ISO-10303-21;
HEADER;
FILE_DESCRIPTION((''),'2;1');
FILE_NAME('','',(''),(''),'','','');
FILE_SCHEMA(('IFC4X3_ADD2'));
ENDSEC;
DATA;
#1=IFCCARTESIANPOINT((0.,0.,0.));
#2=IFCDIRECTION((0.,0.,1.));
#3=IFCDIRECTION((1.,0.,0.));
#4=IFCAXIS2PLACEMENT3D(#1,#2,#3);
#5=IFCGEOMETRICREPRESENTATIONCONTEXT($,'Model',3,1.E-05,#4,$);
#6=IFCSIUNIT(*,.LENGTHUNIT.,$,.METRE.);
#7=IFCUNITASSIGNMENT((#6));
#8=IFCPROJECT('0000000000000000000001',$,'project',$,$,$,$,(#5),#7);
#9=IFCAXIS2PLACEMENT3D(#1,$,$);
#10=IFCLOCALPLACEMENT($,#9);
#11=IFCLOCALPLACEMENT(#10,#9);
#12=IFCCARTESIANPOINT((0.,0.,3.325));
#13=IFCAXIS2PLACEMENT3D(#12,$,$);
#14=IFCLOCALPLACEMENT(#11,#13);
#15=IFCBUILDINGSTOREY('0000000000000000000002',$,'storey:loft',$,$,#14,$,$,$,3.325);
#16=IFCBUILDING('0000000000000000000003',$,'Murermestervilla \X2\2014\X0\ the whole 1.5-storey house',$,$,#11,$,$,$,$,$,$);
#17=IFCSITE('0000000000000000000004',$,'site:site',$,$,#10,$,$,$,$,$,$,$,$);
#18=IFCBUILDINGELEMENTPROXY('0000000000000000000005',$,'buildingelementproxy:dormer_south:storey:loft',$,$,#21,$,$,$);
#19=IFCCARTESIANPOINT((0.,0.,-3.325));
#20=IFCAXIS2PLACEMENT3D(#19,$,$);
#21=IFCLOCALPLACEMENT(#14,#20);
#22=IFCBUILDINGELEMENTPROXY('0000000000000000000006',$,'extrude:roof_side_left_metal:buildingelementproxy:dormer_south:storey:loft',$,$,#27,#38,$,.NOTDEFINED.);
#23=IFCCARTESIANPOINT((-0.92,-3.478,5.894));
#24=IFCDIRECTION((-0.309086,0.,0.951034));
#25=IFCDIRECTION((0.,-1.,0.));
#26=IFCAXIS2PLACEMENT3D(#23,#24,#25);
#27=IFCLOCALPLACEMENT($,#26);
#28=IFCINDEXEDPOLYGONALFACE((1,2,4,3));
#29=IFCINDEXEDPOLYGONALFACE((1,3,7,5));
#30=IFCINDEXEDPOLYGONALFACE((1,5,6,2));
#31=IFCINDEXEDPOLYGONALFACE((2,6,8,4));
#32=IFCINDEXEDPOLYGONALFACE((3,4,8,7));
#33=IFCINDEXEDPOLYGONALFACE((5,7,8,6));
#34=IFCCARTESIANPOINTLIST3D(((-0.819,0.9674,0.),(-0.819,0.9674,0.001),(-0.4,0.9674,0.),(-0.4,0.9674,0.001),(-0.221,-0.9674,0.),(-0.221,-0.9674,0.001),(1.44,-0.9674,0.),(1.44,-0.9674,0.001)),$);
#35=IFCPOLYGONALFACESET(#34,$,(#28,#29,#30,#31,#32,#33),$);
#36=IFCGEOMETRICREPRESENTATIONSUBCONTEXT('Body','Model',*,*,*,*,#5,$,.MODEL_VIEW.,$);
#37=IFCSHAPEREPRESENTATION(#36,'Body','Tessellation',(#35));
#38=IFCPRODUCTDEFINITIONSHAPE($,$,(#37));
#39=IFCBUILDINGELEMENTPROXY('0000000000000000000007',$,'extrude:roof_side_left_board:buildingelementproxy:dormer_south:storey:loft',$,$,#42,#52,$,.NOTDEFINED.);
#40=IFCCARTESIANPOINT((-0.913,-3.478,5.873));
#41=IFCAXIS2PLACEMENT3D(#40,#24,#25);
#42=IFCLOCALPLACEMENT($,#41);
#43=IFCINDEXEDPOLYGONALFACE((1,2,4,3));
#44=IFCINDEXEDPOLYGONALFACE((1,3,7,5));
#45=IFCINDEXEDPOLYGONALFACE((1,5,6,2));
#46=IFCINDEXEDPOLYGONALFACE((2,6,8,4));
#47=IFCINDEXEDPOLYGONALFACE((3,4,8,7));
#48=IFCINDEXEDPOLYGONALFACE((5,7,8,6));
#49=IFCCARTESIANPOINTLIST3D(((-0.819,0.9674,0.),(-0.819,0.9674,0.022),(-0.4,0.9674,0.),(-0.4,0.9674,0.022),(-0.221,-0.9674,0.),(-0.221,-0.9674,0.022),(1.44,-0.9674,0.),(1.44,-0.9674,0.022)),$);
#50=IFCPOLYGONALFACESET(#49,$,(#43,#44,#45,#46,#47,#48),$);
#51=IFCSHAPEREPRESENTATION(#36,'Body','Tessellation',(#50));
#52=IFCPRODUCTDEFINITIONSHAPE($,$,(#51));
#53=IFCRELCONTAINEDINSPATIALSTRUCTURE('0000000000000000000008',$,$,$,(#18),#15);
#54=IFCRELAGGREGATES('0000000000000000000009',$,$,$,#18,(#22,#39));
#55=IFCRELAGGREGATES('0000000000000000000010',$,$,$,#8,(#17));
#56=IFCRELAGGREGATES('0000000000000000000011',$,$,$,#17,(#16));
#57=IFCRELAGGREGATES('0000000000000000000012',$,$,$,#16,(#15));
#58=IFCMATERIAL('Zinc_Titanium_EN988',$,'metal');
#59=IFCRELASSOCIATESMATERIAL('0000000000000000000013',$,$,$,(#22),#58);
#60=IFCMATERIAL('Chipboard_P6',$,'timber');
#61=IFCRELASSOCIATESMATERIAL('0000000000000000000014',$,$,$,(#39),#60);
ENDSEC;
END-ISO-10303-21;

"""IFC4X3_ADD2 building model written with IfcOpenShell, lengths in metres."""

from ifc_helpers import new_model, si_unit, frame, origin, origin_with_axes, place, context, subcontext, project, spatial, polyline, outline, extrude, material, element, aggregate, save


model = new_model("IFC4X3_ADD2")

# Units and contexts
model_context = context("Model", 3, precision=1e-05, world=origin_with_axes())
body_context = subcontext(model_context, "Body", "Model", "MODEL_VIEW")
ifc_project = project(units=[si_unit("LENGTHUNIT", "METRE")], contexts=[model_context])

# Site, building, storey
site_placement = place(None, origin())
site = spatial("IfcSite", under=ifc_project, at=site_placement, Name="site:site")
building_placement = place(site_placement, origin())
building = spatial("IfcBuilding", under=site, at=building_placement, Name="Murermestervilla — the whole 1.5-storey house")
storey_placement = place(building_placement, frame((0.0, 0.0, 3.325)))
storey = spatial("IfcBuildingStorey", under=building, at=storey_placement, Name="storey:loft", Elevation=3.325)

# Shared definitions
placement_1 = place(storey_placement, frame((0.0, 0.0, -3.325)))

# Building element proxy
proxy_1 = element("IfcBuildingElementProxy", 1, at=placement_1, inside=storey, Name="buildingelementproxy:dormer_south:storey:loft")
ifc_material_1 = material(Name="Zinc_Titanium_EN988", Category="metal")

# Building element proxies
proxy_2_placement = place(None, frame((-0.92, -3.478, 5.894), z_axis=(-0.309086, 0.0, 0.951034), x_axis=(0.0, -1.0, 0.0)))
proxy_2 = element("IfcBuildingElementProxy", 2, at=proxy_2_placement, material=ifc_material_1, Name="extrude:roof_side_left_metal:buildingelementproxy:dormer_south:storey:loft", PredefinedType="NOTDEFINED", context=body_context, shape_type="SweptSolid", body=[
    extrude(outline(polyline([(1.44, -0.9674), (-0.4, 0.9674), (-0.819, 0.9674), (-0.221, -0.9674), (1.44, -0.9674)])), origin(), (0.0, 0.0, 1.0), 0.001),
])
ifc_material_2 = material(Name="Chipboard_P6", Category="timber")
proxy_3_placement = place(None, frame((-0.913, -3.478, 5.873), z_axis=(-0.309086, 0.0, 0.951034), x_axis=(0.0, -1.0, 0.0)))
proxy_3 = element("IfcBuildingElementProxy", 3, at=proxy_3_placement, material=ifc_material_2, Name="extrude:roof_side_left_board:buildingelementproxy:dormer_south:storey:loft", PredefinedType="NOTDEFINED", context=body_context, shape_type="SweptSolid", body=[
    extrude(outline(polyline([(1.44, -0.9674), (-0.4, 0.9674), (-0.819, 0.9674), (-0.221, -0.9674), (1.44, -0.9674)])), origin(), (0.0, 0.0, 1.0), 0.022),
])
aggregate(proxy_1, [proxy_2, proxy_3])

save(model, "model.ifc")
